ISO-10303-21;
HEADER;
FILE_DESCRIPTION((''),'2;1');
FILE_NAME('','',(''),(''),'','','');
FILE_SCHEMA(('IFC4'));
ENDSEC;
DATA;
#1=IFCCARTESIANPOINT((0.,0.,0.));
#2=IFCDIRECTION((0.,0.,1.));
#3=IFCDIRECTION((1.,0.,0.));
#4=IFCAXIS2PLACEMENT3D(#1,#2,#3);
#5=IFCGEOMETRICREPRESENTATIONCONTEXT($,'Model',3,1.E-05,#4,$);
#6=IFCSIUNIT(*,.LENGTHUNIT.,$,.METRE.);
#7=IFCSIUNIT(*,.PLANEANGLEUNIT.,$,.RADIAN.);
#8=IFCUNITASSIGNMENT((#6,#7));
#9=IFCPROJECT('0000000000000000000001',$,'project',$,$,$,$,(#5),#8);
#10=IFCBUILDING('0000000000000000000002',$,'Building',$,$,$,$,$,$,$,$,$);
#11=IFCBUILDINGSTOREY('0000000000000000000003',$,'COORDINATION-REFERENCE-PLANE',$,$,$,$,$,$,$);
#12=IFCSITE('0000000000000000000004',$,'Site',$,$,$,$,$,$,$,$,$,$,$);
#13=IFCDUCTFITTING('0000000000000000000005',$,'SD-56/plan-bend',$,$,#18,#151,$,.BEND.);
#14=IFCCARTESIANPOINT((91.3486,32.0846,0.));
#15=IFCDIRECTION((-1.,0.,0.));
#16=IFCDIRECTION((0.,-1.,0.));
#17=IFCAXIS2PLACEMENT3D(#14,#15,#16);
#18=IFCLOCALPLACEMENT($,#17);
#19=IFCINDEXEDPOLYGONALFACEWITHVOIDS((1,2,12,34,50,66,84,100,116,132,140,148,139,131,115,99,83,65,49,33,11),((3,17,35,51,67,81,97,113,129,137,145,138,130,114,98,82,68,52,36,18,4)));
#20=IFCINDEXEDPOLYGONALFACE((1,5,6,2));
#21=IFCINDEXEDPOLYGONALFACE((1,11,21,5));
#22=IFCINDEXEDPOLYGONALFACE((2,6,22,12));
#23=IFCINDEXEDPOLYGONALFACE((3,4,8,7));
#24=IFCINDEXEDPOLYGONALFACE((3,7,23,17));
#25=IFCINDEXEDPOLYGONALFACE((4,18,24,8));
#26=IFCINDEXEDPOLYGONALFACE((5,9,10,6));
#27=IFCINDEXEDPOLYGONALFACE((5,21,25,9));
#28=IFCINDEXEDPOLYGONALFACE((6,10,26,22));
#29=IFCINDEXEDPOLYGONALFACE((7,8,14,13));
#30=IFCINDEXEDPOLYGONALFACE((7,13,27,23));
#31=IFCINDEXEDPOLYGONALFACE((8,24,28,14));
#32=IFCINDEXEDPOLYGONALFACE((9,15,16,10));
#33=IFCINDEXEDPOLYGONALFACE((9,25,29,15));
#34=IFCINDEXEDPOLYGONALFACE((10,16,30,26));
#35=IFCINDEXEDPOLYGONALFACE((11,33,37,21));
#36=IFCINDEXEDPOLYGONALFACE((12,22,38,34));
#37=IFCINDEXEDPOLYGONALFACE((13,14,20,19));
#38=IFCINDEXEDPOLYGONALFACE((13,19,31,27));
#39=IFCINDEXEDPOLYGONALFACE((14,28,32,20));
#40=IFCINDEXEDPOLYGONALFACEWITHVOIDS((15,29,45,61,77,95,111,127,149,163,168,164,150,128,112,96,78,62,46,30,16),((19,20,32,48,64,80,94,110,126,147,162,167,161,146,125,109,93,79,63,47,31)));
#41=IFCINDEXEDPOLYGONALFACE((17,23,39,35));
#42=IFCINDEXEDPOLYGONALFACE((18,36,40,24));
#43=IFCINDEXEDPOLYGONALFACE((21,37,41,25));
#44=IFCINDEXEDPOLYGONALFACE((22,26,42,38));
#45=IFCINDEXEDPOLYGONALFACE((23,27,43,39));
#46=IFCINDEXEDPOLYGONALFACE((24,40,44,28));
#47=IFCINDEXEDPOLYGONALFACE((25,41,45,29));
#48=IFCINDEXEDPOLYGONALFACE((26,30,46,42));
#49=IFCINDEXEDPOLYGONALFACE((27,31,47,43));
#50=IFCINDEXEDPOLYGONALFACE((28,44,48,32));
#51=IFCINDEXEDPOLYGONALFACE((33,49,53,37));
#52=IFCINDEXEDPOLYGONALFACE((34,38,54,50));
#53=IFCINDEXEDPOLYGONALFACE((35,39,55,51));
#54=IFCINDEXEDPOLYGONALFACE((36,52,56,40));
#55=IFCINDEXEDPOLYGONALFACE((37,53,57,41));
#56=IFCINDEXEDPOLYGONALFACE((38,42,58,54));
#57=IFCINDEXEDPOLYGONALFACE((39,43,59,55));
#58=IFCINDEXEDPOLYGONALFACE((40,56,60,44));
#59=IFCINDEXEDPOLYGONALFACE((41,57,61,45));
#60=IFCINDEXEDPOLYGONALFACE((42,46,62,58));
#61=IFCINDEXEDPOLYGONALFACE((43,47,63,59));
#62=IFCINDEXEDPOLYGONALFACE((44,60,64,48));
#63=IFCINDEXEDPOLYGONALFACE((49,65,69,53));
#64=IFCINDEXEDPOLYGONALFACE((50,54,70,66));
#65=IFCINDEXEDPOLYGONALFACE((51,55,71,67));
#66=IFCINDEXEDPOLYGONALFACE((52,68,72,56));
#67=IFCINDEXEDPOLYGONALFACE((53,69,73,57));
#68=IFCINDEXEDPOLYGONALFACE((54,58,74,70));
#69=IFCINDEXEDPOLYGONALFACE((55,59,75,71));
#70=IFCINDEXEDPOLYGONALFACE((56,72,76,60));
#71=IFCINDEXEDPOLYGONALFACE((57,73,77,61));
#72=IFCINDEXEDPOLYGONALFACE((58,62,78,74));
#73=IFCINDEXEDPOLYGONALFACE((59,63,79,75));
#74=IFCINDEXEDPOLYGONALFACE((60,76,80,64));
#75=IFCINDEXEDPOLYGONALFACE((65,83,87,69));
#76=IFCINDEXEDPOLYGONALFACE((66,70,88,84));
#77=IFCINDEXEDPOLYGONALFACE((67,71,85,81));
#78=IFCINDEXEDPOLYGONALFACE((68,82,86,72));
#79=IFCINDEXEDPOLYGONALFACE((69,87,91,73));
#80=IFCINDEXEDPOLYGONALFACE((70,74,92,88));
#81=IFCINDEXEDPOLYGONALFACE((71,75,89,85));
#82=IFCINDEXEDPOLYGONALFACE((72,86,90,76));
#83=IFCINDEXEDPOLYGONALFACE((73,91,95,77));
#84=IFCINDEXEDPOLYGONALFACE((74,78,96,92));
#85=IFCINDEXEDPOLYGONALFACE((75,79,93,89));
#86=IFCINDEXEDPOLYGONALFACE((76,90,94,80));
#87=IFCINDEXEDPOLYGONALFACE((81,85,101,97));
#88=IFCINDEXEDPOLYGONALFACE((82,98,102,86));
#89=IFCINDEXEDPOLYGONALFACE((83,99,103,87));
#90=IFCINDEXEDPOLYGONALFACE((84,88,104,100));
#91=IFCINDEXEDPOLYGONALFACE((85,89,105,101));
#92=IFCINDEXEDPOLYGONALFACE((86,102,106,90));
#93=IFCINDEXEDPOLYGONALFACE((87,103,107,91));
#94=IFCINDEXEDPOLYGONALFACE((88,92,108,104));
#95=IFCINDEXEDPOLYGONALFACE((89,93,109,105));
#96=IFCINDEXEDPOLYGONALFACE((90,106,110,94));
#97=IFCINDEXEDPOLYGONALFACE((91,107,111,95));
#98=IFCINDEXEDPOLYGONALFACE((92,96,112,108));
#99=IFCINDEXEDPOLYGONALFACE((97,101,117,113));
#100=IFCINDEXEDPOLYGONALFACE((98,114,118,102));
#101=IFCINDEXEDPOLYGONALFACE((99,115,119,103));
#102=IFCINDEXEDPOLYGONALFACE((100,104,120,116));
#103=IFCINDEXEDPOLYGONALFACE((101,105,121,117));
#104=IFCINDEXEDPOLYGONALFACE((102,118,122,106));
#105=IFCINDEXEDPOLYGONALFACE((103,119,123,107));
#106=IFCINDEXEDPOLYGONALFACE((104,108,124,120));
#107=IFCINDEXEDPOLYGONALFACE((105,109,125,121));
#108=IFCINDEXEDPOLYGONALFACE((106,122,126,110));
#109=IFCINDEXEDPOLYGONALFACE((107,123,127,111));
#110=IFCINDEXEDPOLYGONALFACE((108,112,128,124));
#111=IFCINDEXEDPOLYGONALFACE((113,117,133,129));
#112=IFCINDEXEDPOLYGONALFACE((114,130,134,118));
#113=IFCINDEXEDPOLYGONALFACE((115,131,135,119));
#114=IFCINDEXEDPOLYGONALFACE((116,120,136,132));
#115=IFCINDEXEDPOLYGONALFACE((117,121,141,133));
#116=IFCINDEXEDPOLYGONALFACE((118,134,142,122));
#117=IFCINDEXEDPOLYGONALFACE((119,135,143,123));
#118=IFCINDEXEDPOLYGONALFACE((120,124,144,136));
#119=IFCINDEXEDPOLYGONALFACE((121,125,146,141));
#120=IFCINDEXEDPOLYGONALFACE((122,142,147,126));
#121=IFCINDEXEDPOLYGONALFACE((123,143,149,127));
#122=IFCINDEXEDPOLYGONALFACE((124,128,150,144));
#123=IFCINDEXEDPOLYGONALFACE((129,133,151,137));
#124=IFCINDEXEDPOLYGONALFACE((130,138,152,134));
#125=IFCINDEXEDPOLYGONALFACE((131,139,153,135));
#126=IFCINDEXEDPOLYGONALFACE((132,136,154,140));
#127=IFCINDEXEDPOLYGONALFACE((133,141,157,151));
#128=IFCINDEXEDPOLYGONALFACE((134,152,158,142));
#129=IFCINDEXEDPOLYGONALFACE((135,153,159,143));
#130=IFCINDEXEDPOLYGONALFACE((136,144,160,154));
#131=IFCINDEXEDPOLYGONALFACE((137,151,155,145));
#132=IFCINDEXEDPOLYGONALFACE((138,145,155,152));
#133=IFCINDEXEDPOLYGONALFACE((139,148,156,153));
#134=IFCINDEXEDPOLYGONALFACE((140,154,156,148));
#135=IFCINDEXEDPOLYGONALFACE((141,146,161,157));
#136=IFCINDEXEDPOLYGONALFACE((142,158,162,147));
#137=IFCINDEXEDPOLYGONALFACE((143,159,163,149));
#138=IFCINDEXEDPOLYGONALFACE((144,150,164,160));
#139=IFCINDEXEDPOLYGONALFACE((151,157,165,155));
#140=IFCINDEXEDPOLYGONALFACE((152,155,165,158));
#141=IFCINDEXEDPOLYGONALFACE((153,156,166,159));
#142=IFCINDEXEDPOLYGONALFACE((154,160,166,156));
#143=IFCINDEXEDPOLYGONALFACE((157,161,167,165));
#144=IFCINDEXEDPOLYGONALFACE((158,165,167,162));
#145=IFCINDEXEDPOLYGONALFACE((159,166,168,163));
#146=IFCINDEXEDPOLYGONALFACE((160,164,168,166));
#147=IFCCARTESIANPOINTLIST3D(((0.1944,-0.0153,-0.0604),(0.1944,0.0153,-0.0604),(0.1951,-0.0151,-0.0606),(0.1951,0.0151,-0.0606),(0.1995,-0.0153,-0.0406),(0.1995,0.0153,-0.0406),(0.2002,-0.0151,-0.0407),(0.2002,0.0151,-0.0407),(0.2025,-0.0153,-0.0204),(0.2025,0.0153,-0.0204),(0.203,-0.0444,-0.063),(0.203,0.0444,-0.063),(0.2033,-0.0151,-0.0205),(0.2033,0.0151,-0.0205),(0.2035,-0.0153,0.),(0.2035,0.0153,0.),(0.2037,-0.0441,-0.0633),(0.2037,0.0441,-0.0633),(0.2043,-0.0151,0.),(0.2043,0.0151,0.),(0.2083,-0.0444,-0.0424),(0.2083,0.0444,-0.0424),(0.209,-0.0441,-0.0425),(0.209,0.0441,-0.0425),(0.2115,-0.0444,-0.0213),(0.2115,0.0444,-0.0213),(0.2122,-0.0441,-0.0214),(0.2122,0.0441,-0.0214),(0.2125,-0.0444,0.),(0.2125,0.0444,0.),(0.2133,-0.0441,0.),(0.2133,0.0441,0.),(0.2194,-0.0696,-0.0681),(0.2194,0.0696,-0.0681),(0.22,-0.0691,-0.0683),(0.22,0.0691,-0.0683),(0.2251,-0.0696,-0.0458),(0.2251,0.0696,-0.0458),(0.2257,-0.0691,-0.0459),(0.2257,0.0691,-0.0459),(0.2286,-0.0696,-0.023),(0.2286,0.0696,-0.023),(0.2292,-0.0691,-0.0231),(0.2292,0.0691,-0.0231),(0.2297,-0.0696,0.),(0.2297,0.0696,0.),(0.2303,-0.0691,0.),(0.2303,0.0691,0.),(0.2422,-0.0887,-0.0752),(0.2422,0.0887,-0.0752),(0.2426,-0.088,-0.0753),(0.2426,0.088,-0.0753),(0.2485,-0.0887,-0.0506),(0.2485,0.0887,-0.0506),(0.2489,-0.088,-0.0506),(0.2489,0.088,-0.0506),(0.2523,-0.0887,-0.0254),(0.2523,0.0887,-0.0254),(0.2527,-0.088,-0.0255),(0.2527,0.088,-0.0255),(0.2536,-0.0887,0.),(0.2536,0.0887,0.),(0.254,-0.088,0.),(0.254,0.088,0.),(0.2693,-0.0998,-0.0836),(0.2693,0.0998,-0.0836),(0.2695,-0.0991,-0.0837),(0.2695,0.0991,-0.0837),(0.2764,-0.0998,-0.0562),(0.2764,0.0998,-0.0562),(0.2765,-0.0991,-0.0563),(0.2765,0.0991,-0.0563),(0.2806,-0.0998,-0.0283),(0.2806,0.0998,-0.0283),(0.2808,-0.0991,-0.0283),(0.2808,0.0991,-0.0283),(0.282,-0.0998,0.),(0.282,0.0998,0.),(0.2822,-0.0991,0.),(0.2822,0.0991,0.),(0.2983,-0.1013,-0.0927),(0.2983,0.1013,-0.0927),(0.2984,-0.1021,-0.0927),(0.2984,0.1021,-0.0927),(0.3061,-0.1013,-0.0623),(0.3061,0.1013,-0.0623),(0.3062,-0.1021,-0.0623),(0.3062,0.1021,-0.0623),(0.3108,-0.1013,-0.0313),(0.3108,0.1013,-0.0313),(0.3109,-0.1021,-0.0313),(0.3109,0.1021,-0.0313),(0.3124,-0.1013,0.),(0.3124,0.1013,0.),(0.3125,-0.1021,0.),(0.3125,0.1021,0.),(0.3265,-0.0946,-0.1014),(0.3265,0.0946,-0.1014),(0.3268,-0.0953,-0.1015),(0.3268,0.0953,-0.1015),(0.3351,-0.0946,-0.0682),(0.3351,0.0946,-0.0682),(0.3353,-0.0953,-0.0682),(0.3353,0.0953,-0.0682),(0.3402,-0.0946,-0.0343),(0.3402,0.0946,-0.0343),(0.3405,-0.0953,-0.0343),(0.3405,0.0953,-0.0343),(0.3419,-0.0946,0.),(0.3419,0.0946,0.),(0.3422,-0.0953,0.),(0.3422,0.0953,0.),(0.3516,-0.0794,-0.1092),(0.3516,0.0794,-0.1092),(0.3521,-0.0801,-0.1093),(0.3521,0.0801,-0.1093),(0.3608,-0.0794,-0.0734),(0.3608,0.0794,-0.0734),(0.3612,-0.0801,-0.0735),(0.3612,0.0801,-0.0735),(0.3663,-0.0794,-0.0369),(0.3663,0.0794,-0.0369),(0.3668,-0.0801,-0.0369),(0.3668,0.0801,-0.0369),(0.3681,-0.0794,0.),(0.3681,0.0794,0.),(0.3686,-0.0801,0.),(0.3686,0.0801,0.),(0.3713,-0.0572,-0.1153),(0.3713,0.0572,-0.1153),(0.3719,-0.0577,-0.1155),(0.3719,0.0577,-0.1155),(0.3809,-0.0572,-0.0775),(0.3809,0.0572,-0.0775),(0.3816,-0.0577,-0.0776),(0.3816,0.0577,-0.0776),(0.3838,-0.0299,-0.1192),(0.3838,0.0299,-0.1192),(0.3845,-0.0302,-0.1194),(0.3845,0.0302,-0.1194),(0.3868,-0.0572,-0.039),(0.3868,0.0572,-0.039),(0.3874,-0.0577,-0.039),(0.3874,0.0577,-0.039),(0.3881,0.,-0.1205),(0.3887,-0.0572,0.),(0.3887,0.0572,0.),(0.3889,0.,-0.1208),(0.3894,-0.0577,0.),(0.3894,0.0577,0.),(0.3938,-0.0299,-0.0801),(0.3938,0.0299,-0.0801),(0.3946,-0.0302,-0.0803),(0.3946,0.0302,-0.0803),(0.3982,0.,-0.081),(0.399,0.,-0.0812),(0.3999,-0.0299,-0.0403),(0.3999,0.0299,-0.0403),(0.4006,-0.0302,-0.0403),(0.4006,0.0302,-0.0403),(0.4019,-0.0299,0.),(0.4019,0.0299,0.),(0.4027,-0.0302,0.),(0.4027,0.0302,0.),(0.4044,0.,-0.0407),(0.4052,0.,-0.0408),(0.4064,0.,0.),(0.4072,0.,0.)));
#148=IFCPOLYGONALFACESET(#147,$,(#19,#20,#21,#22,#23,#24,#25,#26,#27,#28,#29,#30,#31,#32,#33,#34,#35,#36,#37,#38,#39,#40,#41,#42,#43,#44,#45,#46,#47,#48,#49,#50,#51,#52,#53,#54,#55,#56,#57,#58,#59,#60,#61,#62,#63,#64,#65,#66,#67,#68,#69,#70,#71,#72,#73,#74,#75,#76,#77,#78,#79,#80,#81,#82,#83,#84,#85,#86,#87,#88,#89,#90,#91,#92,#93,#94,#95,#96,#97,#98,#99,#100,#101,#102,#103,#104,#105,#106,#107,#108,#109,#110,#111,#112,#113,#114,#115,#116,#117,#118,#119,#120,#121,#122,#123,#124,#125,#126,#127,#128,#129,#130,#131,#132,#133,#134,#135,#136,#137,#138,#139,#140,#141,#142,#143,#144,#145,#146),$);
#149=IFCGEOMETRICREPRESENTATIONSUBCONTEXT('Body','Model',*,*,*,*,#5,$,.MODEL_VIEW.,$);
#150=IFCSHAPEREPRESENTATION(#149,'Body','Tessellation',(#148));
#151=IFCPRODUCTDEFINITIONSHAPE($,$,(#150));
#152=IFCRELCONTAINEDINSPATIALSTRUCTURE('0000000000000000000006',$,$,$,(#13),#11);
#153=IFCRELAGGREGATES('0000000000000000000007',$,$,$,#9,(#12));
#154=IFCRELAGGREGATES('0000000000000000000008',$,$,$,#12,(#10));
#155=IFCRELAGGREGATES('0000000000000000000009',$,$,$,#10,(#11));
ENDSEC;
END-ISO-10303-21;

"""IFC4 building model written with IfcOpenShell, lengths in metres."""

from ifc_helpers import new_model, entity, si_unit, frame, origin_with_axes, place, context, subcontext, project, spatial, element, save


model = new_model("IFC4")

# Units and contexts
model_context = context("Model", 3, precision=1e-05, world=origin_with_axes())
body_context_1 = subcontext(model_context, "Body", "Model", "MODEL_VIEW")
ifc_project = project(units=[si_unit("LENGTHUNIT", "METRE"), si_unit("PLANEANGLEUNIT", "RADIAN")], contexts=[model_context])

# Site, building, storey
site = spatial("IfcSite", under=ifc_project, Name="Site")
building = spatial("IfcBuilding", under=site, Name="Building")
storey = spatial("IfcBuildingStorey", under=building, Name="COORDINATION-REFERENCE-PLANE")

# Duct fitting
duct_fitting_1_placement = place(None, frame((91.3486, 32.0846, 0.0), z_axis=(-1.0, 0.0, 0.0), x_axis=(0.0, -1.0, 0.0)))
element("IfcDuctFitting", 1, at=duct_fitting_1_placement, inside=storey, Name="SD-56/plan-bend", PredefinedType="BEND", context=body_context_1, shape_type="SweptSolid", body=[
    entity("IfcRevolvedAreaSolid", entity("IfcCircleHollowProfileDef", "AREA", None, entity("IfcAxis2Placement2D", entity("IfcCartesianPoint", [0.3048, 0.0])), 0.1024, 0.0008), entity("IfcAxis2Placement3D", entity("IfcCartesianPoint", [0.0, 0.0, 0.0]), entity("IfcDirection", [0.0, 0.0, 1.0]), entity("IfcDirection", [1.0, 0.0, 0.0])), entity("IfcAxis1Placement", entity("IfcCartesianPoint", [0.0, 0.0, 0.0]), entity("IfcDirection", [0.0, 1.0, 0.0])), 0.301119),
])

save(model, "model.ifc")
